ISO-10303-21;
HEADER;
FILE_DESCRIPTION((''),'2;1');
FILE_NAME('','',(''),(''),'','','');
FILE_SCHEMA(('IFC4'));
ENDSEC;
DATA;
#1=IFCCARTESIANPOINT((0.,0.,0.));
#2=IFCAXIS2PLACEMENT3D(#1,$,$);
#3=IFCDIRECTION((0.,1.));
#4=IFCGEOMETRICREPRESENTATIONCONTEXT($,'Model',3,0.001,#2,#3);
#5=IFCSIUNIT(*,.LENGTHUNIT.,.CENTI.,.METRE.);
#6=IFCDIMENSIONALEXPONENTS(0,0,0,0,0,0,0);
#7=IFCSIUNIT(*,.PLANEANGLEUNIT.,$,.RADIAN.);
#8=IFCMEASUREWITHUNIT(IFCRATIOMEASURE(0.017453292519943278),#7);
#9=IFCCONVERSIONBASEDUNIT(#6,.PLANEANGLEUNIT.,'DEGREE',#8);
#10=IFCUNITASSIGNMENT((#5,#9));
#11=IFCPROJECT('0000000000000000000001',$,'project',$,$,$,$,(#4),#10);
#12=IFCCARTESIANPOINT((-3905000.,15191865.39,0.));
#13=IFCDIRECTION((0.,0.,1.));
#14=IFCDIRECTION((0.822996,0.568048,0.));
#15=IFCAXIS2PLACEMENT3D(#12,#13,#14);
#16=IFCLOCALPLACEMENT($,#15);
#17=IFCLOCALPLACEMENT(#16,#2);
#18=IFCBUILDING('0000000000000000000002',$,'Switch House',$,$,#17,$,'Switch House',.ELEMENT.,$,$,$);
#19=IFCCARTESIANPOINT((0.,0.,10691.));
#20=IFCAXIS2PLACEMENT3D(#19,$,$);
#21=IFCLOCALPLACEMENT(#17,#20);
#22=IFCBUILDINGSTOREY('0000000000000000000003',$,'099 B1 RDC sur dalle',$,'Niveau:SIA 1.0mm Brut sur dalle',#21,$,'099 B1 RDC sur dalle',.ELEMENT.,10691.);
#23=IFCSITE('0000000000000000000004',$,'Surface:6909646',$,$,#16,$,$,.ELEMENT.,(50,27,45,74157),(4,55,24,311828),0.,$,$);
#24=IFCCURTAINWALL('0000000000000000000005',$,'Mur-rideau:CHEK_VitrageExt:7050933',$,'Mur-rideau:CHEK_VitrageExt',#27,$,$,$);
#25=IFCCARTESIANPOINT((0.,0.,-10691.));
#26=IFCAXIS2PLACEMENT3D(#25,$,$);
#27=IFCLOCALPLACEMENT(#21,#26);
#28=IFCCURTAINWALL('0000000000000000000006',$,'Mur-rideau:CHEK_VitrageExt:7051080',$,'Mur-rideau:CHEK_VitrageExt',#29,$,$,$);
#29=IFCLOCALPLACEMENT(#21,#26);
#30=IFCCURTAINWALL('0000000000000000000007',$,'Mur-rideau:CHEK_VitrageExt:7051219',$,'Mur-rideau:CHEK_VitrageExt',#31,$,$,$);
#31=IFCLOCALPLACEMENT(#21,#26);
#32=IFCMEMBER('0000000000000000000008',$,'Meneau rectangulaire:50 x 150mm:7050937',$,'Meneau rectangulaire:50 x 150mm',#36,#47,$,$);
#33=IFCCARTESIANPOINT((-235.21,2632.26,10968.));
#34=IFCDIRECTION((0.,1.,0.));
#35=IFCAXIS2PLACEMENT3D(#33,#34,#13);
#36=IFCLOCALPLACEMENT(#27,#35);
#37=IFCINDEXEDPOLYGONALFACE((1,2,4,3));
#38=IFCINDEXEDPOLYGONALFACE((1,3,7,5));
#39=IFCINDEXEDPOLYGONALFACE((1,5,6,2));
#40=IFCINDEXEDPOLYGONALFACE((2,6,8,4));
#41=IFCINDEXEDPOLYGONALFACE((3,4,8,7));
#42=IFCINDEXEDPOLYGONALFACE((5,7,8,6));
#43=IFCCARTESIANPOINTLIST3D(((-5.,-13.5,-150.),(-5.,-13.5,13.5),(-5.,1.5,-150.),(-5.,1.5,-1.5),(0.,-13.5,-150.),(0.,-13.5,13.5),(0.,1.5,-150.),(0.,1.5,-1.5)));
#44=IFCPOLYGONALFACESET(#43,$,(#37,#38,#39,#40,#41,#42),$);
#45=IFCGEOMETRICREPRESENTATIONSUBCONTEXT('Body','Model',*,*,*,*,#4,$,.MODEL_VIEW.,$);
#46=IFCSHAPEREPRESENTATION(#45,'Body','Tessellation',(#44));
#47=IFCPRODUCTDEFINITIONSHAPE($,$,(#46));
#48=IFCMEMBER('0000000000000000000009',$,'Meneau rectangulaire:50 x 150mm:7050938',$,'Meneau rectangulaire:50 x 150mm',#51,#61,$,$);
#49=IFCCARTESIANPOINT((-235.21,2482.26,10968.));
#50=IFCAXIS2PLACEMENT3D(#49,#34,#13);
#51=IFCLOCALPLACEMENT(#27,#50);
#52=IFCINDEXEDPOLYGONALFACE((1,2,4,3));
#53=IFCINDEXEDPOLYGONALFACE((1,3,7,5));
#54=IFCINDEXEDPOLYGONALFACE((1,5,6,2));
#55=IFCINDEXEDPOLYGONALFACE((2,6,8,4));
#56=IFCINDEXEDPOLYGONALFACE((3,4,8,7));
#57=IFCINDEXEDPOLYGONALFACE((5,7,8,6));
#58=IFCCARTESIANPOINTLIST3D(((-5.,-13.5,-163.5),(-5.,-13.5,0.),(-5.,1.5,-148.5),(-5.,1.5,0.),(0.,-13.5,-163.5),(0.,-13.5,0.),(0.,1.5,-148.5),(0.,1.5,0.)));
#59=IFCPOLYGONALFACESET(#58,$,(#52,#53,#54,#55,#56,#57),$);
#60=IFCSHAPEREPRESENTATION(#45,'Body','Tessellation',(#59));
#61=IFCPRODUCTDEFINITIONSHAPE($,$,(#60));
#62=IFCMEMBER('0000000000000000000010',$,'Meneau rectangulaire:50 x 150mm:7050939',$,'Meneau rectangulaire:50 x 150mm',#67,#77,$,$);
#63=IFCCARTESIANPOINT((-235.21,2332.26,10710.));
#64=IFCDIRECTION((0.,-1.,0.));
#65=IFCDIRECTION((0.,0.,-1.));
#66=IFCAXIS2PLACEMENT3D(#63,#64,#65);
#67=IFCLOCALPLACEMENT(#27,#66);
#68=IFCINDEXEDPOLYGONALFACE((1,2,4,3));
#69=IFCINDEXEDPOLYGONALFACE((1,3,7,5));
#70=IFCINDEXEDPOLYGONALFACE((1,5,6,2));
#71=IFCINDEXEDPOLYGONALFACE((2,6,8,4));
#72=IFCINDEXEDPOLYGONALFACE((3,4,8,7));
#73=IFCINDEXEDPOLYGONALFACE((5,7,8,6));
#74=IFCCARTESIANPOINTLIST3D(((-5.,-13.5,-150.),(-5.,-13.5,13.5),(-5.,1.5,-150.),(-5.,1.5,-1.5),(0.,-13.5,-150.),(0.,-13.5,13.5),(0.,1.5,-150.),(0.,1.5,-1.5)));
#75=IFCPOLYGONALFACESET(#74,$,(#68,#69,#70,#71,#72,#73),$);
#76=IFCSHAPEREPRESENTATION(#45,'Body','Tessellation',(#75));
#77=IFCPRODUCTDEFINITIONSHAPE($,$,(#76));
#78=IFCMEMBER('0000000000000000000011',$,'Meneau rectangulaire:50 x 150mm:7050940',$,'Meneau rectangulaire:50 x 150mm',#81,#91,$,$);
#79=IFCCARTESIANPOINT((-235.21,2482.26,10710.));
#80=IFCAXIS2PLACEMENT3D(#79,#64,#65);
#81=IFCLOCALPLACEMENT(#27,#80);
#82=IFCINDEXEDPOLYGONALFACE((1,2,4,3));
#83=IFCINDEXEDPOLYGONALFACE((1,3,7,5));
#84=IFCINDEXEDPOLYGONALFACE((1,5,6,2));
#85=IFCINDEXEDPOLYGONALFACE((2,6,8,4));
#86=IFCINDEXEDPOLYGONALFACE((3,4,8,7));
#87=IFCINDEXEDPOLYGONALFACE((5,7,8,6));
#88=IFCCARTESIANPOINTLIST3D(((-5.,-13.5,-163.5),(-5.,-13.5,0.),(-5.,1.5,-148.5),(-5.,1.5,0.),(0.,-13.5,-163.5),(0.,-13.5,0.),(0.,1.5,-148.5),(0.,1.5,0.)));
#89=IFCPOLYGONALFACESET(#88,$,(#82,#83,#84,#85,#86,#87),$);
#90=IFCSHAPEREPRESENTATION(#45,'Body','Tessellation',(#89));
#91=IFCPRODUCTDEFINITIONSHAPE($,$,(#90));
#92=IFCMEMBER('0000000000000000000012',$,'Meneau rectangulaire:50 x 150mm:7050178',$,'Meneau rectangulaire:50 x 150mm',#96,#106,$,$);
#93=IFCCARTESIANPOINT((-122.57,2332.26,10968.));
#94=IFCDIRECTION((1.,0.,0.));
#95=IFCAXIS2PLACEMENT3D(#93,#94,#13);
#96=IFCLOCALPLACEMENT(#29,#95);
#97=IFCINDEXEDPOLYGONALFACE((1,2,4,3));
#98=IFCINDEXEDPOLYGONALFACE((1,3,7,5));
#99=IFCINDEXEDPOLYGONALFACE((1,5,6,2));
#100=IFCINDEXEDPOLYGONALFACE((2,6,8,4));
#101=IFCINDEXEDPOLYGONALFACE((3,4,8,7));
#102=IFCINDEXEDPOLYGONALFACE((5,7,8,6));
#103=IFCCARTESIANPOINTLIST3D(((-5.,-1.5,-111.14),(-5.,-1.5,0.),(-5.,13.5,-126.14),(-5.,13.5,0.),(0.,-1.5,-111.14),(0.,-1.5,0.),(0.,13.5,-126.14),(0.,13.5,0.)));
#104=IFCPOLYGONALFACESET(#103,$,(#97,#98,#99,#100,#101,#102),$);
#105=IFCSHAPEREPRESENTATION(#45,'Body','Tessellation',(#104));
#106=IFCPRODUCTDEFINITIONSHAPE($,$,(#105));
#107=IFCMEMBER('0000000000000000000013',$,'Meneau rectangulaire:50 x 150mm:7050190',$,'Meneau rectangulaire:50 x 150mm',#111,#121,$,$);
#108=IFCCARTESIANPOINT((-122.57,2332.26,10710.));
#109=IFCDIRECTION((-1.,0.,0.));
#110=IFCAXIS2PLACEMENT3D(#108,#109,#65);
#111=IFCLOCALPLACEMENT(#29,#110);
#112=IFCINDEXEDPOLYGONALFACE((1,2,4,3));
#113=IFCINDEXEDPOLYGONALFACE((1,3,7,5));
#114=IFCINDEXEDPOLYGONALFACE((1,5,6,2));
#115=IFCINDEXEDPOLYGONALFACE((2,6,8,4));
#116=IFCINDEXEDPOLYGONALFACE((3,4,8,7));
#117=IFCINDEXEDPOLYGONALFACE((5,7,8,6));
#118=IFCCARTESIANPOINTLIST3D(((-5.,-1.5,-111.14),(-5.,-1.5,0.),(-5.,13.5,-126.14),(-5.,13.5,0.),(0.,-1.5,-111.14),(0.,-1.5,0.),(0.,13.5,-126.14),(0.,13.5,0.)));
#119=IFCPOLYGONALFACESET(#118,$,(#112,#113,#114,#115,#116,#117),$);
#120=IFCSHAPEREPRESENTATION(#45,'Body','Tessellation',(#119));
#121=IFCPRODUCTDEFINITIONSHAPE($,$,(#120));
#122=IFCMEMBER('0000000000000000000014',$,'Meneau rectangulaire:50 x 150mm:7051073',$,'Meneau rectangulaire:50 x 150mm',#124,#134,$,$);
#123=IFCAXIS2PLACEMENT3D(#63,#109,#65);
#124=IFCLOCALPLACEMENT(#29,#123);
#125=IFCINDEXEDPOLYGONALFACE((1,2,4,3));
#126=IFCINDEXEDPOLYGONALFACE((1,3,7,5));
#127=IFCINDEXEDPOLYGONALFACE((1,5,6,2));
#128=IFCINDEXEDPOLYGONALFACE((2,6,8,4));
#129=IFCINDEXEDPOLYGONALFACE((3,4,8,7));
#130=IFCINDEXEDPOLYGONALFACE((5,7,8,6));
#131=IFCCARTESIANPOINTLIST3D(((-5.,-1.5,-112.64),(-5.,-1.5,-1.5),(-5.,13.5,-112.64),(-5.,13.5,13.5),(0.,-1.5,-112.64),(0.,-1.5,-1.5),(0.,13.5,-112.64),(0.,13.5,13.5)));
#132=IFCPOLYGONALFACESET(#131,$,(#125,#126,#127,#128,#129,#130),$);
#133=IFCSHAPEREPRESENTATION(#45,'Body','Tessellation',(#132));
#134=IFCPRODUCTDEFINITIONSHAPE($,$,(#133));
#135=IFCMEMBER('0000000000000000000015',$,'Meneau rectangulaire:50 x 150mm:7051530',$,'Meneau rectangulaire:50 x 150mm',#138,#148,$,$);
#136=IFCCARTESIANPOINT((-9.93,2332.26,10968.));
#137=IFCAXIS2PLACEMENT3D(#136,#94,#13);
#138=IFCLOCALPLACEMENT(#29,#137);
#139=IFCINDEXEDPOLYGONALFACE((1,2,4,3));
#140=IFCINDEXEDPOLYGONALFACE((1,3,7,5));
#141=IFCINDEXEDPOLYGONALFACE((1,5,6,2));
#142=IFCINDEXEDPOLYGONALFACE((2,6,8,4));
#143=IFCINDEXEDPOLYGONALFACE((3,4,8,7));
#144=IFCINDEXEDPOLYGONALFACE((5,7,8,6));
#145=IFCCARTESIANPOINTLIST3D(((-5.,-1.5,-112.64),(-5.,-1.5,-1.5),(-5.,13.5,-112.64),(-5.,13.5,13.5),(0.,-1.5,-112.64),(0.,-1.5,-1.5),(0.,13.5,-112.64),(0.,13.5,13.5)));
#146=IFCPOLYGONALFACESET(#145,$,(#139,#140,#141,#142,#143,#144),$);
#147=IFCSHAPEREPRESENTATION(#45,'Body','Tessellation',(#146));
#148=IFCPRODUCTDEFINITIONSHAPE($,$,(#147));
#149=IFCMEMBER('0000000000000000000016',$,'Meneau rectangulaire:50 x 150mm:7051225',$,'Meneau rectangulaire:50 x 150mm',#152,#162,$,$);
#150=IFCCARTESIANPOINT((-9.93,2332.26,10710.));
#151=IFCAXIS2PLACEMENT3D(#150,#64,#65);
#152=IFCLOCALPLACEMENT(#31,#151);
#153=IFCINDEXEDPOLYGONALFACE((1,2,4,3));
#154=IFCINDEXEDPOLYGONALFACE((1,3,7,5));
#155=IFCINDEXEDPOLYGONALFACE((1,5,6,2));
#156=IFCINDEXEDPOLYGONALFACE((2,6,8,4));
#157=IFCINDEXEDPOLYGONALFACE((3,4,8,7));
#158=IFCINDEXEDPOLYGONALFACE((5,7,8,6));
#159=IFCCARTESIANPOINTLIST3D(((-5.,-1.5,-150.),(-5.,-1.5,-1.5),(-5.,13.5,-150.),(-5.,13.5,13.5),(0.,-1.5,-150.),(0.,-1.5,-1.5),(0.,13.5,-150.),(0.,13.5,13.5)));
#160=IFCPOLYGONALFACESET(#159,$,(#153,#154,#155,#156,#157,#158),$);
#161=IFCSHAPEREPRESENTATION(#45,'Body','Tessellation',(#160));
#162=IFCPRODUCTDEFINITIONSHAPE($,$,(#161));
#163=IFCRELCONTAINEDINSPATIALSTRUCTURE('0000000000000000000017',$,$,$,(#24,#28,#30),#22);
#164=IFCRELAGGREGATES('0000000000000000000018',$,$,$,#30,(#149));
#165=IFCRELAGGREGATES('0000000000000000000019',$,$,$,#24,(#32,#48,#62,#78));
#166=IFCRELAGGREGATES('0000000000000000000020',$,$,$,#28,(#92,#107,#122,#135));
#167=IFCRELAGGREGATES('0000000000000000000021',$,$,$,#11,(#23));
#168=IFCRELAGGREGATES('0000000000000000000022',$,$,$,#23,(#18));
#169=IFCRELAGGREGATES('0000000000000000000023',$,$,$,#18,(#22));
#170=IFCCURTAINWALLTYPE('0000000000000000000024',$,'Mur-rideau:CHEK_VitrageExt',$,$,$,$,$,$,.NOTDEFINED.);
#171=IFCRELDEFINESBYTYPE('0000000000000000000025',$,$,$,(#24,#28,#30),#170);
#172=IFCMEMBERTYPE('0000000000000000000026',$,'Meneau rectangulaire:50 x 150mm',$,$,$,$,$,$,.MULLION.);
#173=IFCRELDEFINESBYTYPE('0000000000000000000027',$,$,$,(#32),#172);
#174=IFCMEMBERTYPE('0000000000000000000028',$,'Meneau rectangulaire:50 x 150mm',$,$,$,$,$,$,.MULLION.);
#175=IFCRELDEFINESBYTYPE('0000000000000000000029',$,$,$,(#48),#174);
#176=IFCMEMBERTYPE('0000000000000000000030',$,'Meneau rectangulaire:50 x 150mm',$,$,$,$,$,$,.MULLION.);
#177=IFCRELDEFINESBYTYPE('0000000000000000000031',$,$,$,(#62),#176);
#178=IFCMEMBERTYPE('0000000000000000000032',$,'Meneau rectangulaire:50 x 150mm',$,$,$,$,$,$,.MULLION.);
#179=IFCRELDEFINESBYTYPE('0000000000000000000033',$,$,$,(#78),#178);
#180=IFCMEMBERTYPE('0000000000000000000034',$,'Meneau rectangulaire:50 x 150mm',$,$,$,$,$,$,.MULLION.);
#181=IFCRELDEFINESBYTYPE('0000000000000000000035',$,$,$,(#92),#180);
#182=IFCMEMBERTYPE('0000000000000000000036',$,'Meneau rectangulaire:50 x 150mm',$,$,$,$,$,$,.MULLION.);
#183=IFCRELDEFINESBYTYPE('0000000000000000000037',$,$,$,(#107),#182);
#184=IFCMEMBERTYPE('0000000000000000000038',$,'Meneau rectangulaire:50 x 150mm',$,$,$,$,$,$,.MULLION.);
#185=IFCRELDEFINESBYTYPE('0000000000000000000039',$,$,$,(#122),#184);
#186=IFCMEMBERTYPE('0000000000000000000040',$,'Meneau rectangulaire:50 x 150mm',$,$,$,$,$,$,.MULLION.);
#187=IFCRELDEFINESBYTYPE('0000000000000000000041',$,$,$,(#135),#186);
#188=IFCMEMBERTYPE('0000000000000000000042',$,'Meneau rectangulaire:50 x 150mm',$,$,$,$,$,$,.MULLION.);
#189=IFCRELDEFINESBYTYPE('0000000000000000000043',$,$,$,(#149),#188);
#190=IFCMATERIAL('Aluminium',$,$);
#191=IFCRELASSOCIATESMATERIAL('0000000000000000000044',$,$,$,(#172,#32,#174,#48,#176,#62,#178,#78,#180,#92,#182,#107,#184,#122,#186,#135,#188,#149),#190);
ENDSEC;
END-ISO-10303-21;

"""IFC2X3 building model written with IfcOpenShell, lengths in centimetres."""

from ifc_helpers import new_model, entity, si_unit, converted_unit, direction, frame, origin, origin_2d_with_axis, place, context, subcontext, project, spatial, rectangle, extrude, clip, halfspace, source, transform, mapped, material, type_object, type_shapes, element, aggregate, save


model = new_model("IFC2X3")

# Units and contexts
model_context = context("Model", 3, precision=0.001, world=origin(), true_north=direction((0.0, 1.0)))
body_context = subcontext(model_context, "Body", "Model", "MODEL_VIEW")
ifc_project = project(units=[si_unit("LENGTHUNIT", "METRE", prefix="CENTI"), converted_unit("PLANEANGLEUNIT", "DEGREE", entity("IfcRatioMeasure", 0.017453292519943278), si_unit("PLANEANGLEUNIT", "RADIAN"), dimensions=[0, 0, 0, 0, 0, 0, 0])], contexts=[model_context])

# Site, building, storey
site_placement = place(None, frame((-3905000.0, 15191865.39, 0.0), z_axis=(0.0, 0.0, 1.0), x_axis=(0.822996, 0.568048, 0.0)))
site = spatial("IfcSite", under=ifc_project, at=site_placement, Name="Surface:6909646", CompositionType="ELEMENT", RefLatitude=(50, 27, 45, 74157), RefLongitude=(4, 55, 24, 311828), RefElevation=0.0)
building_placement = place(site_placement, origin())
building = spatial("IfcBuilding", under=site, at=building_placement, Name="Switch House", LongName="Switch House", CompositionType="ELEMENT")
storey_placement = place(building_placement, frame((0.0, 0.0, 10691.0)))
storey = spatial("IfcBuildingStorey", under=building, at=storey_placement, Name="099 B1 RDC sur dalle", ObjectType="Niveau:SIA 1.0mm Brut sur dalle", LongName="099 B1 RDC sur dalle", CompositionType="ELEMENT", Elevation=10691.0)

# Curtain wall
curtain_wall_type = type_object("IfcCurtainWallType", Name="Mur-rideau:CHEK_VitrageExt", PredefinedType="NOTDEFINED")
curtain_wall_1_placement = place(storey_placement, frame((0.0, 0.0, -10691.0)))
curtain_wall_1 = element("IfcCurtainWall", 1, at=curtain_wall_1_placement, inside=storey, type_object=curtain_wall_type, Name="Mur-rideau:CHEK_VitrageExt:7050933", ObjectType="Mur-rideau:CHEK_VitrageExt")
ifc_material_1 = material(Name="Aluminium")

# Curtain walls
curtain_wall_2_placement = place(storey_placement, frame((0.0, 0.0, -10691.0)))
curtain_wall_2 = element("IfcCurtainWall", 2, at=curtain_wall_2_placement, inside=storey, type_object=curtain_wall_type, Name="Mur-rideau:CHEK_VitrageExt:7051080", ObjectType="Mur-rideau:CHEK_VitrageExt")
curtain_wall_3_placement = place(storey_placement, frame((0.0, 0.0, -10691.0)))
curtain_wall_3 = element("IfcCurtainWall", 3, at=curtain_wall_3_placement, inside=storey, type_object=curtain_wall_type, Name="Mur-rideau:CHEK_VitrageExt:7051219", ObjectType="Mur-rideau:CHEK_VitrageExt")

# Members
member_type_1 = type_object("IfcMemberType", Name="Meneau rectangulaire:50 x 150mm", PredefinedType="MULLION", material=ifc_material_1)
shared_shape_1 = source(origin(), body_context, "Body", "SweptSolid", [
    clip(extrude(rectangle(XDim=15.0, YDim=5.0, at=origin_2d_with_axis()), frame((-2.5, -6.0, -150.0), z_axis=(0.0, 0.0, 1.0), x_axis=(0.0, -1.0, 0.0)), (0.0, 0.0, 1.0), 163.5), halfspace(frame((-30.48, 0.0, 0.0), z_axis=(0.0, 0.707107, 0.707107), x_axis=(0.0, 0.707107, -0.707107)), False)),
])
type_shapes(member_type_1, [shared_shape_1])
member_1_placement = place(curtain_wall_1_placement, frame((-235.21, 2632.26, 10968.0), z_axis=(0.0, 1.0, 0.0), x_axis=(0.0, 0.0, 1.0)))
member_1 = element("IfcMember", 4, at=member_1_placement, type_object=member_type_1, material=ifc_material_1, Name="Meneau rectangulaire:50 x 150mm:7050937", ObjectType="Meneau rectangulaire:50 x 150mm", context=body_context, shape_type="MappedRepresentation", body=[
    mapped(shared_shape_1, transform((0.0, 0.0, 0.0), scale=1.0)),
])
member_type_2 = type_object("IfcMemberType", Name="Meneau rectangulaire:50 x 150mm", PredefinedType="MULLION", material=ifc_material_1)
shared_shape_2 = source(origin(), body_context, "Body", "SweptSolid", [
    clip(extrude(rectangle(XDim=15.0, YDim=5.0, at=origin_2d_with_axis()), frame((-2.5, -6.0, -163.5), z_axis=(0.0, 0.0, 1.0), x_axis=(0.0, -1.0, 0.0)), (0.0, 0.0, 1.0), 163.5), halfspace(frame((-30.48, 0.0, -150.0), z_axis=(0.0, 0.707107, -0.707107), x_axis=(0.0, 0.707107, 0.707107)), False)),
])
type_shapes(member_type_2, [shared_shape_2])
member_2_placement = place(curtain_wall_1_placement, frame((-235.21, 2482.26, 10968.0), z_axis=(0.0, 1.0, 0.0), x_axis=(0.0, 0.0, 1.0)))
member_2 = element("IfcMember", 5, at=member_2_placement, type_object=member_type_2, material=ifc_material_1, Name="Meneau rectangulaire:50 x 150mm:7050938", ObjectType="Meneau rectangulaire:50 x 150mm", context=body_context, shape_type="MappedRepresentation", body=[
    mapped(shared_shape_2, transform((0.0, 0.0, 0.0), scale=1.0)),
])
member_type_3 = type_object("IfcMemberType", Name="Meneau rectangulaire:50 x 150mm", PredefinedType="MULLION", material=ifc_material_1)
shared_shape_3 = source(origin(), body_context, "Body", "SweptSolid", [
    clip(extrude(rectangle(XDim=15.0, YDim=5.0, at=origin_2d_with_axis()), frame((-2.5, -6.0, -150.0), z_axis=(0.0, 0.0, 1.0), x_axis=(0.0, -1.0, 0.0)), (0.0, 0.0, 1.0), 163.5), halfspace(frame((-30.48, 0.0, 0.0), z_axis=(0.0, 0.707107, 0.707107), x_axis=(0.0, 0.707107, -0.707107)), False)),
])
type_shapes(member_type_3, [shared_shape_3])
member_3_placement = place(curtain_wall_1_placement, frame((-235.21, 2332.26, 10710.0), z_axis=(0.0, -1.0, 0.0), x_axis=(0.0, 0.0, -1.0)))
member_3 = element("IfcMember", 6, at=member_3_placement, type_object=member_type_3, material=ifc_material_1, Name="Meneau rectangulaire:50 x 150mm:7050939", ObjectType="Meneau rectangulaire:50 x 150mm", context=body_context, shape_type="MappedRepresentation", body=[
    mapped(shared_shape_3, transform((0.0, 0.0, 0.0), scale=1.0)),
])
member_type_4 = type_object("IfcMemberType", Name="Meneau rectangulaire:50 x 150mm", PredefinedType="MULLION", material=ifc_material_1)
shared_shape_4 = source(origin(), body_context, "Body", "SweptSolid", [
    clip(extrude(rectangle(XDim=15.0, YDim=5.0, at=origin_2d_with_axis()), frame((-2.5, -6.0, -163.5), z_axis=(0.0, 0.0, 1.0), x_axis=(0.0, -1.0, 0.0)), (0.0, 0.0, 1.0), 163.5), halfspace(frame((-30.48, 0.0, -150.0), z_axis=(0.0, 0.707107, -0.707107), x_axis=(0.0, 0.707107, 0.707107)), False)),
])
type_shapes(member_type_4, [shared_shape_4])
member_4_placement = place(curtain_wall_1_placement, frame((-235.21, 2482.26, 10710.0), z_axis=(0.0, -1.0, 0.0), x_axis=(0.0, 0.0, -1.0)))
member_4 = element("IfcMember", 7, at=member_4_placement, type_object=member_type_4, material=ifc_material_1, Name="Meneau rectangulaire:50 x 150mm:7050940", ObjectType="Meneau rectangulaire:50 x 150mm", context=body_context, shape_type="MappedRepresentation", body=[
    mapped(shared_shape_4, transform((0.0, 0.0, 0.0), scale=1.0)),
])
member_type_5 = type_object("IfcMemberType", Name="Meneau rectangulaire:50 x 150mm", PredefinedType="MULLION", material=ifc_material_1)
shared_shape_5 = source(origin(), body_context, "Body", "SweptSolid", [
    clip(extrude(rectangle(XDim=15.0, YDim=5.0, at=origin_2d_with_axis()), frame((-2.5, 6.0, -126.14), z_axis=(0.0, 0.0, 1.0), x_axis=(0.0, -1.0, 0.0)), (0.0, 0.0, 1.0), 126.14), halfspace(frame((30.48, 0.0, -112.64), z_axis=(0.0, -0.707107, -0.707107), x_axis=(0.0, -0.707107, 0.707107)), False)),
])
type_shapes(member_type_5, [shared_shape_5])
member_5_placement = place(curtain_wall_2_placement, frame((-122.57, 2332.26, 10968.0), z_axis=(1.0, 0.0, 0.0), x_axis=(0.0, 0.0, 1.0)))
member_5 = element("IfcMember", 8, at=member_5_placement, type_object=member_type_5, material=ifc_material_1, Name="Meneau rectangulaire:50 x 150mm:7050178", ObjectType="Meneau rectangulaire:50 x 150mm", context=body_context, shape_type="MappedRepresentation", body=[
    mapped(shared_shape_5, transform((0.0, 0.0, 0.0), scale=1.0)),
])
member_type_6 = type_object("IfcMemberType", Name="Meneau rectangulaire:50 x 150mm", PredefinedType="MULLION", material=ifc_material_1)
shared_shape_6 = source(origin(), body_context, "Body", "SweptSolid", [
    clip(extrude(rectangle(XDim=15.0, YDim=5.0, at=origin_2d_with_axis()), frame((-2.5, 6.0, -126.14), z_axis=(0.0, 0.0, 1.0), x_axis=(0.0, -1.0, 0.0)), (0.0, 0.0, 1.0), 126.14), halfspace(frame((30.48, 0.0, -112.64), z_axis=(0.0, -0.707107, -0.707107), x_axis=(0.0, -0.707107, 0.707107)), False)),
])
type_shapes(member_type_6, [shared_shape_6])
member_6_placement = place(curtain_wall_2_placement, frame((-122.57, 2332.26, 10710.0), z_axis=(-1.0, 0.0, 0.0), x_axis=(0.0, 0.0, -1.0)))
member_6 = element("IfcMember", 9, at=member_6_placement, type_object=member_type_6, material=ifc_material_1, Name="Meneau rectangulaire:50 x 150mm:7050190", ObjectType="Meneau rectangulaire:50 x 150mm", context=body_context, shape_type="MappedRepresentation", body=[
    mapped(shared_shape_6, transform((0.0, 0.0, 0.0), scale=1.0)),
])
member_type_7 = type_object("IfcMemberType", Name="Meneau rectangulaire:50 x 150mm", PredefinedType="MULLION", material=ifc_material_1)
shared_shape_7 = source(origin(), body_context, "Body", "SweptSolid", [
    clip(extrude(rectangle(XDim=15.0, YDim=5.0, at=origin_2d_with_axis()), frame((-2.5, 6.0, -112.64), z_axis=(0.0, 0.0, 1.0), x_axis=(0.0, -1.0, 0.0)), (0.0, 0.0, 1.0), 126.14), halfspace(frame((30.48, 0.0, 0.0), z_axis=(0.0, -0.707107, 0.707107), x_axis=(0.0, -0.707107, -0.707107)), False)),
])
type_shapes(member_type_7, [shared_shape_7])
member_7_placement = place(curtain_wall_2_placement, frame((-235.21, 2332.26, 10710.0), z_axis=(-1.0, 0.0, 0.0), x_axis=(0.0, 0.0, -1.0)))
member_7 = element("IfcMember", 10, at=member_7_placement, type_object=member_type_7, material=ifc_material_1, Name="Meneau rectangulaire:50 x 150mm:7051073", ObjectType="Meneau rectangulaire:50 x 150mm", context=body_context, shape_type="MappedRepresentation", body=[
    mapped(shared_shape_7, transform((0.0, 0.0, 0.0), scale=1.0)),
])
member_type_8 = type_object("IfcMemberType", Name="Meneau rectangulaire:50 x 150mm", PredefinedType="MULLION", material=ifc_material_1)
shared_shape_8 = source(origin(), body_context, "Body", "SweptSolid", [
    clip(extrude(rectangle(XDim=15.0, YDim=5.0, at=origin_2d_with_axis()), frame((-2.5, 6.0, -112.64), z_axis=(0.0, 0.0, 1.0), x_axis=(0.0, -1.0, 0.0)), (0.0, 0.0, 1.0), 126.14), halfspace(frame((30.48, 0.0, 0.0), z_axis=(0.0, -0.707107, 0.707107), x_axis=(0.0, -0.707107, -0.707107)), False)),
])
type_shapes(member_type_8, [shared_shape_8])
member_8_placement = place(curtain_wall_2_placement, frame((-9.93, 2332.26, 10968.0), z_axis=(1.0, 0.0, 0.0), x_axis=(0.0, 0.0, 1.0)))
member_8 = element("IfcMember", 11, at=member_8_placement, type_object=member_type_8, material=ifc_material_1, Name="Meneau rectangulaire:50 x 150mm:7051530", ObjectType="Meneau rectangulaire:50 x 150mm", context=body_context, shape_type="MappedRepresentation", body=[
    mapped(shared_shape_8, transform((0.0, 0.0, 0.0), scale=1.0)),
])
member_type_9 = type_object("IfcMemberType", Name="Meneau rectangulaire:50 x 150mm", PredefinedType="MULLION", material=ifc_material_1)
shared_shape_9 = source(origin(), body_context, "Body", "SweptSolid", [
    clip(extrude(rectangle(XDim=15.0, YDim=5.0, at=origin_2d_with_axis()), frame((-2.5, 6.0, -150.0), z_axis=(0.0, 0.0, 1.0), x_axis=(0.0, -1.0, 0.0)), (0.0, 0.0, 1.0), 163.5), halfspace(frame((30.48, 0.0, 0.0), z_axis=(0.0, -0.707107, 0.707107), x_axis=(0.0, -0.707107, -0.707107)), False)),
])
type_shapes(member_type_9, [shared_shape_9])
member_9_placement = place(curtain_wall_3_placement, frame((-9.93, 2332.26, 10710.0), z_axis=(0.0, -1.0, 0.0), x_axis=(0.0, 0.0, -1.0)))
member_9 = element("IfcMember", 12, at=member_9_placement, type_object=member_type_9, material=ifc_material_1, Name="Meneau rectangulaire:50 x 150mm:7051225", ObjectType="Meneau rectangulaire:50 x 150mm", context=body_context, shape_type="MappedRepresentation", body=[
    mapped(shared_shape_9, transform((0.0, 0.0, 0.0), scale=1.0)),
])

aggregate(curtain_wall_3, [member_9])
aggregate(curtain_wall_1, [member_1, member_2, member_3, member_4])
aggregate(curtain_wall_2, [member_5, member_6, member_7, member_8])

save(model, "model.ifc")
